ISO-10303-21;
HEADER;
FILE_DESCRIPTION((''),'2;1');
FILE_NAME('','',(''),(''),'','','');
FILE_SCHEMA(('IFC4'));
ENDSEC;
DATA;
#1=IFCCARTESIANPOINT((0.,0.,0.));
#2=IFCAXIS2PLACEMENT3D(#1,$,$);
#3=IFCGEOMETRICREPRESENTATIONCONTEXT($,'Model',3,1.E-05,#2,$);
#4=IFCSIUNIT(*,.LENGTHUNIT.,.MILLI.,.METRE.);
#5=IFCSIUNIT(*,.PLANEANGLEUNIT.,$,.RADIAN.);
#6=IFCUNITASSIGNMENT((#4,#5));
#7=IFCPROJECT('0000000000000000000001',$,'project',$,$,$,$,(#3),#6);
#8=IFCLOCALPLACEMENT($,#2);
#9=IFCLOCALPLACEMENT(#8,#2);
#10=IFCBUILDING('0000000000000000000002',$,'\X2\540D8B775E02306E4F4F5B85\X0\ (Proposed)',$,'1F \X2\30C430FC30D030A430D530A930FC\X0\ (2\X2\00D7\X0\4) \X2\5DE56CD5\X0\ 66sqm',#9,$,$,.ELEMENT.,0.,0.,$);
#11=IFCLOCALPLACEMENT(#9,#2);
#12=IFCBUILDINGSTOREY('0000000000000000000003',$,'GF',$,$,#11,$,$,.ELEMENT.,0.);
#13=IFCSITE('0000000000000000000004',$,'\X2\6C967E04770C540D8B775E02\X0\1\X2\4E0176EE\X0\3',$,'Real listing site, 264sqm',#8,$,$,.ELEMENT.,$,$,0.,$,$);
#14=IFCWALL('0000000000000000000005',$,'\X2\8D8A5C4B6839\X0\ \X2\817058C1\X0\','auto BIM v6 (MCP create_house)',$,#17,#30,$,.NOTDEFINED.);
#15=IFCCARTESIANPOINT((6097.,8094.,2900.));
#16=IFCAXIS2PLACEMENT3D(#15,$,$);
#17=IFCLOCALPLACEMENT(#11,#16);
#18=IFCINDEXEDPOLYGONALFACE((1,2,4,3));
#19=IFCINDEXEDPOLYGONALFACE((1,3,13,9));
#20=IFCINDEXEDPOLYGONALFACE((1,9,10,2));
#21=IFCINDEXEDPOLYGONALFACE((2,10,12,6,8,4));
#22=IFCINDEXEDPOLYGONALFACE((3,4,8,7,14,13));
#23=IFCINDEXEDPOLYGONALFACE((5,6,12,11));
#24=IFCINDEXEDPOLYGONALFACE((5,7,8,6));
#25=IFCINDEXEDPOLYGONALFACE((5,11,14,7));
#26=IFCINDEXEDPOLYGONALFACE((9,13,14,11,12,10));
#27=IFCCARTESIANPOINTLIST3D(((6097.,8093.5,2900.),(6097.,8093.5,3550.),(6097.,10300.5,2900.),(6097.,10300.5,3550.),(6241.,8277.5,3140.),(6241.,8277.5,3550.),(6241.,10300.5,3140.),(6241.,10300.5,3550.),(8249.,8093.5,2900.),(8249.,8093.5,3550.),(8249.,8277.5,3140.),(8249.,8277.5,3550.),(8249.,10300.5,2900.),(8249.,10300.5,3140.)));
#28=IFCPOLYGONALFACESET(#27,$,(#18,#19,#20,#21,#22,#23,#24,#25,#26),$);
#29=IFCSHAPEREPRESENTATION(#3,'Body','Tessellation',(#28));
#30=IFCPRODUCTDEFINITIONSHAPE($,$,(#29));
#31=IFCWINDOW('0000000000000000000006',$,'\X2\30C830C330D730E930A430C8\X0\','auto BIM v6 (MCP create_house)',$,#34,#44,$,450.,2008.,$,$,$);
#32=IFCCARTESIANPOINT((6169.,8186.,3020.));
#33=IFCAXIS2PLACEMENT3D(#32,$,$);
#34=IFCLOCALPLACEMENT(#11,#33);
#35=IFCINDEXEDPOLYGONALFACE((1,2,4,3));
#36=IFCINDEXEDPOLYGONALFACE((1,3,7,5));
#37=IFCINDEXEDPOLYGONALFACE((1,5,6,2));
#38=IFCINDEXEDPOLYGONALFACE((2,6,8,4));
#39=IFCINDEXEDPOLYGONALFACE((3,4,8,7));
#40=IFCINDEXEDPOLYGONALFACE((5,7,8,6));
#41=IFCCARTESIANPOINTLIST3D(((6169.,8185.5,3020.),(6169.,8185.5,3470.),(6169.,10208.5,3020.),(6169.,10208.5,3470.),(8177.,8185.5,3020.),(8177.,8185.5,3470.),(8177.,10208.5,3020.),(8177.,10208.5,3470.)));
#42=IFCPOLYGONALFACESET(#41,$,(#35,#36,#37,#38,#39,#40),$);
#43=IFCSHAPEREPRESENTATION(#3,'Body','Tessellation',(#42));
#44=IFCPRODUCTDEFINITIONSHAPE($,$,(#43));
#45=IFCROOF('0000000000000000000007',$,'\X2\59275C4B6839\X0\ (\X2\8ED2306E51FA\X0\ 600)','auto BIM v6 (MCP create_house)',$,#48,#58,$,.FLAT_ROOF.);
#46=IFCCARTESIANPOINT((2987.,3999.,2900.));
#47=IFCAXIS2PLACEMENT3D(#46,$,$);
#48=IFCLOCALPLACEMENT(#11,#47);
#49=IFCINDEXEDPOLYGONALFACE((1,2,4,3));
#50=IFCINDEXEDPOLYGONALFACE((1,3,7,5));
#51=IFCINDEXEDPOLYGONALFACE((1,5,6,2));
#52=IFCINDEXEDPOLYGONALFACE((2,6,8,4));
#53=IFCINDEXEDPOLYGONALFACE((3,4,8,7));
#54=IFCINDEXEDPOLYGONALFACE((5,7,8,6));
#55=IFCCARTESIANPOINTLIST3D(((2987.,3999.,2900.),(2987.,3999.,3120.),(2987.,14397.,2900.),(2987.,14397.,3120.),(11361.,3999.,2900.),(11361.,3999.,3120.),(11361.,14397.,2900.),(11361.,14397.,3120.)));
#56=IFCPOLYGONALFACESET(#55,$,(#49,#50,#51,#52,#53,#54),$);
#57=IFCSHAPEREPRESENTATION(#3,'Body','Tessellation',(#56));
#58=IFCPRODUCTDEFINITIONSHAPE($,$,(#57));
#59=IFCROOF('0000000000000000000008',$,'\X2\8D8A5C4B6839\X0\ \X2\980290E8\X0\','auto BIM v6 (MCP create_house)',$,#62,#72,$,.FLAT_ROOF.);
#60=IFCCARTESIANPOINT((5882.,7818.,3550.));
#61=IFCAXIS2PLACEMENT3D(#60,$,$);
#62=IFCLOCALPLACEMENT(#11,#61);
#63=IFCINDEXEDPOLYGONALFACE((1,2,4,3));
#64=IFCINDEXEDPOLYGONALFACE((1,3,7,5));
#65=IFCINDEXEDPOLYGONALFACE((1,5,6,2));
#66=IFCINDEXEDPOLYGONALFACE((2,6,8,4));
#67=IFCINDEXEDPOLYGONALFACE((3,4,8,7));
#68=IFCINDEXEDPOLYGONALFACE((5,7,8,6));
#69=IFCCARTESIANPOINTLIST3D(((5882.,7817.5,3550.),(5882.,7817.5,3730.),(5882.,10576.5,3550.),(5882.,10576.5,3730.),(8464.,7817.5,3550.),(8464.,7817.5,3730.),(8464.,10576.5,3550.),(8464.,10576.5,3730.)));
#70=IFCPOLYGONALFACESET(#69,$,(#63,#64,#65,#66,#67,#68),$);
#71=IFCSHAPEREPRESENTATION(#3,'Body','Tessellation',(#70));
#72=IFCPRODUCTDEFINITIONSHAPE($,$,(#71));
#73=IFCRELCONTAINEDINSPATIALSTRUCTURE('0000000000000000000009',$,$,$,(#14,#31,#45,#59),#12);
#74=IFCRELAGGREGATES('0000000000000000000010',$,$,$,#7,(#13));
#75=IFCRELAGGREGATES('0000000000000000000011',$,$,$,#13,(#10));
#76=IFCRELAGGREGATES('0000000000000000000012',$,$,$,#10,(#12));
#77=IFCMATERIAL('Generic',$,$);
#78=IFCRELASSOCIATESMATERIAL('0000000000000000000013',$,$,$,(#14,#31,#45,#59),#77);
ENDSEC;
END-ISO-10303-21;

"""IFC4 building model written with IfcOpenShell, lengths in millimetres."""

from ifc_helpers import new_model, si_unit, frame, frame_2d, origin, place, context, project, spatial, rectangle, extrude, material, element, fill, save


model = new_model("IFC4")

# Units and contexts
model_context = context("Model", 3, precision=1e-05, world=origin())
ifc_project = project(units=[si_unit("LENGTHUNIT", "METRE", prefix="MILLI"), si_unit("PLANEANGLEUNIT", "RADIAN")], contexts=[model_context])

# Site, building, storey
site_placement = place(None, origin())
site = spatial("IfcSite", under=ifc_project, at=site_placement, Name="沖縄県名護市1丁目3", ObjectType="Real listing site, 264sqm", CompositionType="ELEMENT", RefElevation=0.0)
building_placement = place(site_placement, origin())
building = spatial("IfcBuilding", under=site, at=building_placement, Name="名護市の住宅 (Proposed)", ObjectType="1F ツーバイフォー (2×4) 工法 66sqm", CompositionType="ELEMENT", ElevationOfRefHeight=0.0, ElevationOfTerrain=0.0)
storey_placement = place(building_placement, origin())
storey = spatial("IfcBuildingStorey", under=building, at=storey_placement, Name="GF", CompositionType="ELEMENT", Elevation=0.0)

# Shared definitions
ifc_material = material(Name="Generic")

# Wall, opening, window
wall_1_placement = place(storey_placement, frame((6097.0, 8094.0, 2900.0)))
wall_1 = element("IfcWall", 1, at=wall_1_placement, inside=storey, material=ifc_material, Name="越屋根 腰壁", Description="auto BIM v6 (MCP create_house)", PredefinedType="NOTDEFINED", context=model_context, shape_type="SweptSolid", body=[
    extrude(rectangle(XDim=2152.0, YDim=2207.0, at=frame_2d((1076.0, 1103.0))), frame((6097.0, 8094.0, 2900.0)), (0.0, 0.0, 1.0), 650.0),
])
opening_1_placement = place(storey_placement, frame((6169.0, 8186.0, 3020.0)))
opening_1 = element("IfcOpeningElement", 2, at=opening_1_placement, cuts=wall_1, PredefinedType="NOTDEFINED", context=model_context, shape_type="SweptSolid", body=[
    extrude(rectangle(XDim=2008.0, YDim=2023.0, at=frame_2d((1004.0, 1011.0))), frame((6169.0, 8186.0, 3020.0)), (0.0, 0.0, 1.0), 450.0),
])
window_1_placement = place(storey_placement, frame((6169.0, 8186.0, 3020.0)))
window_1 = element("IfcWindow", 3, at=window_1_placement, inside=storey, material=ifc_material, Name="トップライト", Description="auto BIM v6 (MCP create_house)", OverallHeight=450.0, OverallWidth=2008.0, context=model_context, shape_type="SweptSolid", body=[
    extrude(rectangle(XDim=2008.0, YDim=2023.0, at=frame_2d((1004.0, 1011.0))), frame((6169.0, 8186.0, 3020.0)), (0.0, 0.0, 1.0), 450.0),
])
fill(opening_1, window_1)

# Roofs
roof_1_placement = place(storey_placement, frame((2987.0, 3999.0, 2900.0)))
element("IfcRoof", 4, at=roof_1_placement, inside=storey, material=ifc_material, Name="大屋根 (軒の出 600)", Description="auto BIM v6 (MCP create_house)", PredefinedType="FLAT_ROOF", context=model_context, shape_type="SweptSolid", body=[
    extrude(rectangle(XDim=8374.0, YDim=10398.0, at=frame_2d((4187.0, 5199.0))), frame((2987.0, 3999.0, 2900.0)), (0.0, 0.0, 1.0), 220.0),
])
roof_2_placement = place(storey_placement, frame((5882.0, 7818.0, 3550.0)))
element("IfcRoof", 5, at=roof_2_placement, inside=storey, material=ifc_material, Name="越屋根 頂部", Description="auto BIM v6 (MCP create_house)", PredefinedType="FLAT_ROOF", context=model_context, shape_type="SweptSolid", body=[
    extrude(rectangle(XDim=2582.0, YDim=2759.0, at=frame_2d((1291.0, 1379.0))), frame((5882.0, 7818.0, 3550.0)), (0.0, 0.0, 1.0), 180.0),
])

save(model, "model.ifc")
